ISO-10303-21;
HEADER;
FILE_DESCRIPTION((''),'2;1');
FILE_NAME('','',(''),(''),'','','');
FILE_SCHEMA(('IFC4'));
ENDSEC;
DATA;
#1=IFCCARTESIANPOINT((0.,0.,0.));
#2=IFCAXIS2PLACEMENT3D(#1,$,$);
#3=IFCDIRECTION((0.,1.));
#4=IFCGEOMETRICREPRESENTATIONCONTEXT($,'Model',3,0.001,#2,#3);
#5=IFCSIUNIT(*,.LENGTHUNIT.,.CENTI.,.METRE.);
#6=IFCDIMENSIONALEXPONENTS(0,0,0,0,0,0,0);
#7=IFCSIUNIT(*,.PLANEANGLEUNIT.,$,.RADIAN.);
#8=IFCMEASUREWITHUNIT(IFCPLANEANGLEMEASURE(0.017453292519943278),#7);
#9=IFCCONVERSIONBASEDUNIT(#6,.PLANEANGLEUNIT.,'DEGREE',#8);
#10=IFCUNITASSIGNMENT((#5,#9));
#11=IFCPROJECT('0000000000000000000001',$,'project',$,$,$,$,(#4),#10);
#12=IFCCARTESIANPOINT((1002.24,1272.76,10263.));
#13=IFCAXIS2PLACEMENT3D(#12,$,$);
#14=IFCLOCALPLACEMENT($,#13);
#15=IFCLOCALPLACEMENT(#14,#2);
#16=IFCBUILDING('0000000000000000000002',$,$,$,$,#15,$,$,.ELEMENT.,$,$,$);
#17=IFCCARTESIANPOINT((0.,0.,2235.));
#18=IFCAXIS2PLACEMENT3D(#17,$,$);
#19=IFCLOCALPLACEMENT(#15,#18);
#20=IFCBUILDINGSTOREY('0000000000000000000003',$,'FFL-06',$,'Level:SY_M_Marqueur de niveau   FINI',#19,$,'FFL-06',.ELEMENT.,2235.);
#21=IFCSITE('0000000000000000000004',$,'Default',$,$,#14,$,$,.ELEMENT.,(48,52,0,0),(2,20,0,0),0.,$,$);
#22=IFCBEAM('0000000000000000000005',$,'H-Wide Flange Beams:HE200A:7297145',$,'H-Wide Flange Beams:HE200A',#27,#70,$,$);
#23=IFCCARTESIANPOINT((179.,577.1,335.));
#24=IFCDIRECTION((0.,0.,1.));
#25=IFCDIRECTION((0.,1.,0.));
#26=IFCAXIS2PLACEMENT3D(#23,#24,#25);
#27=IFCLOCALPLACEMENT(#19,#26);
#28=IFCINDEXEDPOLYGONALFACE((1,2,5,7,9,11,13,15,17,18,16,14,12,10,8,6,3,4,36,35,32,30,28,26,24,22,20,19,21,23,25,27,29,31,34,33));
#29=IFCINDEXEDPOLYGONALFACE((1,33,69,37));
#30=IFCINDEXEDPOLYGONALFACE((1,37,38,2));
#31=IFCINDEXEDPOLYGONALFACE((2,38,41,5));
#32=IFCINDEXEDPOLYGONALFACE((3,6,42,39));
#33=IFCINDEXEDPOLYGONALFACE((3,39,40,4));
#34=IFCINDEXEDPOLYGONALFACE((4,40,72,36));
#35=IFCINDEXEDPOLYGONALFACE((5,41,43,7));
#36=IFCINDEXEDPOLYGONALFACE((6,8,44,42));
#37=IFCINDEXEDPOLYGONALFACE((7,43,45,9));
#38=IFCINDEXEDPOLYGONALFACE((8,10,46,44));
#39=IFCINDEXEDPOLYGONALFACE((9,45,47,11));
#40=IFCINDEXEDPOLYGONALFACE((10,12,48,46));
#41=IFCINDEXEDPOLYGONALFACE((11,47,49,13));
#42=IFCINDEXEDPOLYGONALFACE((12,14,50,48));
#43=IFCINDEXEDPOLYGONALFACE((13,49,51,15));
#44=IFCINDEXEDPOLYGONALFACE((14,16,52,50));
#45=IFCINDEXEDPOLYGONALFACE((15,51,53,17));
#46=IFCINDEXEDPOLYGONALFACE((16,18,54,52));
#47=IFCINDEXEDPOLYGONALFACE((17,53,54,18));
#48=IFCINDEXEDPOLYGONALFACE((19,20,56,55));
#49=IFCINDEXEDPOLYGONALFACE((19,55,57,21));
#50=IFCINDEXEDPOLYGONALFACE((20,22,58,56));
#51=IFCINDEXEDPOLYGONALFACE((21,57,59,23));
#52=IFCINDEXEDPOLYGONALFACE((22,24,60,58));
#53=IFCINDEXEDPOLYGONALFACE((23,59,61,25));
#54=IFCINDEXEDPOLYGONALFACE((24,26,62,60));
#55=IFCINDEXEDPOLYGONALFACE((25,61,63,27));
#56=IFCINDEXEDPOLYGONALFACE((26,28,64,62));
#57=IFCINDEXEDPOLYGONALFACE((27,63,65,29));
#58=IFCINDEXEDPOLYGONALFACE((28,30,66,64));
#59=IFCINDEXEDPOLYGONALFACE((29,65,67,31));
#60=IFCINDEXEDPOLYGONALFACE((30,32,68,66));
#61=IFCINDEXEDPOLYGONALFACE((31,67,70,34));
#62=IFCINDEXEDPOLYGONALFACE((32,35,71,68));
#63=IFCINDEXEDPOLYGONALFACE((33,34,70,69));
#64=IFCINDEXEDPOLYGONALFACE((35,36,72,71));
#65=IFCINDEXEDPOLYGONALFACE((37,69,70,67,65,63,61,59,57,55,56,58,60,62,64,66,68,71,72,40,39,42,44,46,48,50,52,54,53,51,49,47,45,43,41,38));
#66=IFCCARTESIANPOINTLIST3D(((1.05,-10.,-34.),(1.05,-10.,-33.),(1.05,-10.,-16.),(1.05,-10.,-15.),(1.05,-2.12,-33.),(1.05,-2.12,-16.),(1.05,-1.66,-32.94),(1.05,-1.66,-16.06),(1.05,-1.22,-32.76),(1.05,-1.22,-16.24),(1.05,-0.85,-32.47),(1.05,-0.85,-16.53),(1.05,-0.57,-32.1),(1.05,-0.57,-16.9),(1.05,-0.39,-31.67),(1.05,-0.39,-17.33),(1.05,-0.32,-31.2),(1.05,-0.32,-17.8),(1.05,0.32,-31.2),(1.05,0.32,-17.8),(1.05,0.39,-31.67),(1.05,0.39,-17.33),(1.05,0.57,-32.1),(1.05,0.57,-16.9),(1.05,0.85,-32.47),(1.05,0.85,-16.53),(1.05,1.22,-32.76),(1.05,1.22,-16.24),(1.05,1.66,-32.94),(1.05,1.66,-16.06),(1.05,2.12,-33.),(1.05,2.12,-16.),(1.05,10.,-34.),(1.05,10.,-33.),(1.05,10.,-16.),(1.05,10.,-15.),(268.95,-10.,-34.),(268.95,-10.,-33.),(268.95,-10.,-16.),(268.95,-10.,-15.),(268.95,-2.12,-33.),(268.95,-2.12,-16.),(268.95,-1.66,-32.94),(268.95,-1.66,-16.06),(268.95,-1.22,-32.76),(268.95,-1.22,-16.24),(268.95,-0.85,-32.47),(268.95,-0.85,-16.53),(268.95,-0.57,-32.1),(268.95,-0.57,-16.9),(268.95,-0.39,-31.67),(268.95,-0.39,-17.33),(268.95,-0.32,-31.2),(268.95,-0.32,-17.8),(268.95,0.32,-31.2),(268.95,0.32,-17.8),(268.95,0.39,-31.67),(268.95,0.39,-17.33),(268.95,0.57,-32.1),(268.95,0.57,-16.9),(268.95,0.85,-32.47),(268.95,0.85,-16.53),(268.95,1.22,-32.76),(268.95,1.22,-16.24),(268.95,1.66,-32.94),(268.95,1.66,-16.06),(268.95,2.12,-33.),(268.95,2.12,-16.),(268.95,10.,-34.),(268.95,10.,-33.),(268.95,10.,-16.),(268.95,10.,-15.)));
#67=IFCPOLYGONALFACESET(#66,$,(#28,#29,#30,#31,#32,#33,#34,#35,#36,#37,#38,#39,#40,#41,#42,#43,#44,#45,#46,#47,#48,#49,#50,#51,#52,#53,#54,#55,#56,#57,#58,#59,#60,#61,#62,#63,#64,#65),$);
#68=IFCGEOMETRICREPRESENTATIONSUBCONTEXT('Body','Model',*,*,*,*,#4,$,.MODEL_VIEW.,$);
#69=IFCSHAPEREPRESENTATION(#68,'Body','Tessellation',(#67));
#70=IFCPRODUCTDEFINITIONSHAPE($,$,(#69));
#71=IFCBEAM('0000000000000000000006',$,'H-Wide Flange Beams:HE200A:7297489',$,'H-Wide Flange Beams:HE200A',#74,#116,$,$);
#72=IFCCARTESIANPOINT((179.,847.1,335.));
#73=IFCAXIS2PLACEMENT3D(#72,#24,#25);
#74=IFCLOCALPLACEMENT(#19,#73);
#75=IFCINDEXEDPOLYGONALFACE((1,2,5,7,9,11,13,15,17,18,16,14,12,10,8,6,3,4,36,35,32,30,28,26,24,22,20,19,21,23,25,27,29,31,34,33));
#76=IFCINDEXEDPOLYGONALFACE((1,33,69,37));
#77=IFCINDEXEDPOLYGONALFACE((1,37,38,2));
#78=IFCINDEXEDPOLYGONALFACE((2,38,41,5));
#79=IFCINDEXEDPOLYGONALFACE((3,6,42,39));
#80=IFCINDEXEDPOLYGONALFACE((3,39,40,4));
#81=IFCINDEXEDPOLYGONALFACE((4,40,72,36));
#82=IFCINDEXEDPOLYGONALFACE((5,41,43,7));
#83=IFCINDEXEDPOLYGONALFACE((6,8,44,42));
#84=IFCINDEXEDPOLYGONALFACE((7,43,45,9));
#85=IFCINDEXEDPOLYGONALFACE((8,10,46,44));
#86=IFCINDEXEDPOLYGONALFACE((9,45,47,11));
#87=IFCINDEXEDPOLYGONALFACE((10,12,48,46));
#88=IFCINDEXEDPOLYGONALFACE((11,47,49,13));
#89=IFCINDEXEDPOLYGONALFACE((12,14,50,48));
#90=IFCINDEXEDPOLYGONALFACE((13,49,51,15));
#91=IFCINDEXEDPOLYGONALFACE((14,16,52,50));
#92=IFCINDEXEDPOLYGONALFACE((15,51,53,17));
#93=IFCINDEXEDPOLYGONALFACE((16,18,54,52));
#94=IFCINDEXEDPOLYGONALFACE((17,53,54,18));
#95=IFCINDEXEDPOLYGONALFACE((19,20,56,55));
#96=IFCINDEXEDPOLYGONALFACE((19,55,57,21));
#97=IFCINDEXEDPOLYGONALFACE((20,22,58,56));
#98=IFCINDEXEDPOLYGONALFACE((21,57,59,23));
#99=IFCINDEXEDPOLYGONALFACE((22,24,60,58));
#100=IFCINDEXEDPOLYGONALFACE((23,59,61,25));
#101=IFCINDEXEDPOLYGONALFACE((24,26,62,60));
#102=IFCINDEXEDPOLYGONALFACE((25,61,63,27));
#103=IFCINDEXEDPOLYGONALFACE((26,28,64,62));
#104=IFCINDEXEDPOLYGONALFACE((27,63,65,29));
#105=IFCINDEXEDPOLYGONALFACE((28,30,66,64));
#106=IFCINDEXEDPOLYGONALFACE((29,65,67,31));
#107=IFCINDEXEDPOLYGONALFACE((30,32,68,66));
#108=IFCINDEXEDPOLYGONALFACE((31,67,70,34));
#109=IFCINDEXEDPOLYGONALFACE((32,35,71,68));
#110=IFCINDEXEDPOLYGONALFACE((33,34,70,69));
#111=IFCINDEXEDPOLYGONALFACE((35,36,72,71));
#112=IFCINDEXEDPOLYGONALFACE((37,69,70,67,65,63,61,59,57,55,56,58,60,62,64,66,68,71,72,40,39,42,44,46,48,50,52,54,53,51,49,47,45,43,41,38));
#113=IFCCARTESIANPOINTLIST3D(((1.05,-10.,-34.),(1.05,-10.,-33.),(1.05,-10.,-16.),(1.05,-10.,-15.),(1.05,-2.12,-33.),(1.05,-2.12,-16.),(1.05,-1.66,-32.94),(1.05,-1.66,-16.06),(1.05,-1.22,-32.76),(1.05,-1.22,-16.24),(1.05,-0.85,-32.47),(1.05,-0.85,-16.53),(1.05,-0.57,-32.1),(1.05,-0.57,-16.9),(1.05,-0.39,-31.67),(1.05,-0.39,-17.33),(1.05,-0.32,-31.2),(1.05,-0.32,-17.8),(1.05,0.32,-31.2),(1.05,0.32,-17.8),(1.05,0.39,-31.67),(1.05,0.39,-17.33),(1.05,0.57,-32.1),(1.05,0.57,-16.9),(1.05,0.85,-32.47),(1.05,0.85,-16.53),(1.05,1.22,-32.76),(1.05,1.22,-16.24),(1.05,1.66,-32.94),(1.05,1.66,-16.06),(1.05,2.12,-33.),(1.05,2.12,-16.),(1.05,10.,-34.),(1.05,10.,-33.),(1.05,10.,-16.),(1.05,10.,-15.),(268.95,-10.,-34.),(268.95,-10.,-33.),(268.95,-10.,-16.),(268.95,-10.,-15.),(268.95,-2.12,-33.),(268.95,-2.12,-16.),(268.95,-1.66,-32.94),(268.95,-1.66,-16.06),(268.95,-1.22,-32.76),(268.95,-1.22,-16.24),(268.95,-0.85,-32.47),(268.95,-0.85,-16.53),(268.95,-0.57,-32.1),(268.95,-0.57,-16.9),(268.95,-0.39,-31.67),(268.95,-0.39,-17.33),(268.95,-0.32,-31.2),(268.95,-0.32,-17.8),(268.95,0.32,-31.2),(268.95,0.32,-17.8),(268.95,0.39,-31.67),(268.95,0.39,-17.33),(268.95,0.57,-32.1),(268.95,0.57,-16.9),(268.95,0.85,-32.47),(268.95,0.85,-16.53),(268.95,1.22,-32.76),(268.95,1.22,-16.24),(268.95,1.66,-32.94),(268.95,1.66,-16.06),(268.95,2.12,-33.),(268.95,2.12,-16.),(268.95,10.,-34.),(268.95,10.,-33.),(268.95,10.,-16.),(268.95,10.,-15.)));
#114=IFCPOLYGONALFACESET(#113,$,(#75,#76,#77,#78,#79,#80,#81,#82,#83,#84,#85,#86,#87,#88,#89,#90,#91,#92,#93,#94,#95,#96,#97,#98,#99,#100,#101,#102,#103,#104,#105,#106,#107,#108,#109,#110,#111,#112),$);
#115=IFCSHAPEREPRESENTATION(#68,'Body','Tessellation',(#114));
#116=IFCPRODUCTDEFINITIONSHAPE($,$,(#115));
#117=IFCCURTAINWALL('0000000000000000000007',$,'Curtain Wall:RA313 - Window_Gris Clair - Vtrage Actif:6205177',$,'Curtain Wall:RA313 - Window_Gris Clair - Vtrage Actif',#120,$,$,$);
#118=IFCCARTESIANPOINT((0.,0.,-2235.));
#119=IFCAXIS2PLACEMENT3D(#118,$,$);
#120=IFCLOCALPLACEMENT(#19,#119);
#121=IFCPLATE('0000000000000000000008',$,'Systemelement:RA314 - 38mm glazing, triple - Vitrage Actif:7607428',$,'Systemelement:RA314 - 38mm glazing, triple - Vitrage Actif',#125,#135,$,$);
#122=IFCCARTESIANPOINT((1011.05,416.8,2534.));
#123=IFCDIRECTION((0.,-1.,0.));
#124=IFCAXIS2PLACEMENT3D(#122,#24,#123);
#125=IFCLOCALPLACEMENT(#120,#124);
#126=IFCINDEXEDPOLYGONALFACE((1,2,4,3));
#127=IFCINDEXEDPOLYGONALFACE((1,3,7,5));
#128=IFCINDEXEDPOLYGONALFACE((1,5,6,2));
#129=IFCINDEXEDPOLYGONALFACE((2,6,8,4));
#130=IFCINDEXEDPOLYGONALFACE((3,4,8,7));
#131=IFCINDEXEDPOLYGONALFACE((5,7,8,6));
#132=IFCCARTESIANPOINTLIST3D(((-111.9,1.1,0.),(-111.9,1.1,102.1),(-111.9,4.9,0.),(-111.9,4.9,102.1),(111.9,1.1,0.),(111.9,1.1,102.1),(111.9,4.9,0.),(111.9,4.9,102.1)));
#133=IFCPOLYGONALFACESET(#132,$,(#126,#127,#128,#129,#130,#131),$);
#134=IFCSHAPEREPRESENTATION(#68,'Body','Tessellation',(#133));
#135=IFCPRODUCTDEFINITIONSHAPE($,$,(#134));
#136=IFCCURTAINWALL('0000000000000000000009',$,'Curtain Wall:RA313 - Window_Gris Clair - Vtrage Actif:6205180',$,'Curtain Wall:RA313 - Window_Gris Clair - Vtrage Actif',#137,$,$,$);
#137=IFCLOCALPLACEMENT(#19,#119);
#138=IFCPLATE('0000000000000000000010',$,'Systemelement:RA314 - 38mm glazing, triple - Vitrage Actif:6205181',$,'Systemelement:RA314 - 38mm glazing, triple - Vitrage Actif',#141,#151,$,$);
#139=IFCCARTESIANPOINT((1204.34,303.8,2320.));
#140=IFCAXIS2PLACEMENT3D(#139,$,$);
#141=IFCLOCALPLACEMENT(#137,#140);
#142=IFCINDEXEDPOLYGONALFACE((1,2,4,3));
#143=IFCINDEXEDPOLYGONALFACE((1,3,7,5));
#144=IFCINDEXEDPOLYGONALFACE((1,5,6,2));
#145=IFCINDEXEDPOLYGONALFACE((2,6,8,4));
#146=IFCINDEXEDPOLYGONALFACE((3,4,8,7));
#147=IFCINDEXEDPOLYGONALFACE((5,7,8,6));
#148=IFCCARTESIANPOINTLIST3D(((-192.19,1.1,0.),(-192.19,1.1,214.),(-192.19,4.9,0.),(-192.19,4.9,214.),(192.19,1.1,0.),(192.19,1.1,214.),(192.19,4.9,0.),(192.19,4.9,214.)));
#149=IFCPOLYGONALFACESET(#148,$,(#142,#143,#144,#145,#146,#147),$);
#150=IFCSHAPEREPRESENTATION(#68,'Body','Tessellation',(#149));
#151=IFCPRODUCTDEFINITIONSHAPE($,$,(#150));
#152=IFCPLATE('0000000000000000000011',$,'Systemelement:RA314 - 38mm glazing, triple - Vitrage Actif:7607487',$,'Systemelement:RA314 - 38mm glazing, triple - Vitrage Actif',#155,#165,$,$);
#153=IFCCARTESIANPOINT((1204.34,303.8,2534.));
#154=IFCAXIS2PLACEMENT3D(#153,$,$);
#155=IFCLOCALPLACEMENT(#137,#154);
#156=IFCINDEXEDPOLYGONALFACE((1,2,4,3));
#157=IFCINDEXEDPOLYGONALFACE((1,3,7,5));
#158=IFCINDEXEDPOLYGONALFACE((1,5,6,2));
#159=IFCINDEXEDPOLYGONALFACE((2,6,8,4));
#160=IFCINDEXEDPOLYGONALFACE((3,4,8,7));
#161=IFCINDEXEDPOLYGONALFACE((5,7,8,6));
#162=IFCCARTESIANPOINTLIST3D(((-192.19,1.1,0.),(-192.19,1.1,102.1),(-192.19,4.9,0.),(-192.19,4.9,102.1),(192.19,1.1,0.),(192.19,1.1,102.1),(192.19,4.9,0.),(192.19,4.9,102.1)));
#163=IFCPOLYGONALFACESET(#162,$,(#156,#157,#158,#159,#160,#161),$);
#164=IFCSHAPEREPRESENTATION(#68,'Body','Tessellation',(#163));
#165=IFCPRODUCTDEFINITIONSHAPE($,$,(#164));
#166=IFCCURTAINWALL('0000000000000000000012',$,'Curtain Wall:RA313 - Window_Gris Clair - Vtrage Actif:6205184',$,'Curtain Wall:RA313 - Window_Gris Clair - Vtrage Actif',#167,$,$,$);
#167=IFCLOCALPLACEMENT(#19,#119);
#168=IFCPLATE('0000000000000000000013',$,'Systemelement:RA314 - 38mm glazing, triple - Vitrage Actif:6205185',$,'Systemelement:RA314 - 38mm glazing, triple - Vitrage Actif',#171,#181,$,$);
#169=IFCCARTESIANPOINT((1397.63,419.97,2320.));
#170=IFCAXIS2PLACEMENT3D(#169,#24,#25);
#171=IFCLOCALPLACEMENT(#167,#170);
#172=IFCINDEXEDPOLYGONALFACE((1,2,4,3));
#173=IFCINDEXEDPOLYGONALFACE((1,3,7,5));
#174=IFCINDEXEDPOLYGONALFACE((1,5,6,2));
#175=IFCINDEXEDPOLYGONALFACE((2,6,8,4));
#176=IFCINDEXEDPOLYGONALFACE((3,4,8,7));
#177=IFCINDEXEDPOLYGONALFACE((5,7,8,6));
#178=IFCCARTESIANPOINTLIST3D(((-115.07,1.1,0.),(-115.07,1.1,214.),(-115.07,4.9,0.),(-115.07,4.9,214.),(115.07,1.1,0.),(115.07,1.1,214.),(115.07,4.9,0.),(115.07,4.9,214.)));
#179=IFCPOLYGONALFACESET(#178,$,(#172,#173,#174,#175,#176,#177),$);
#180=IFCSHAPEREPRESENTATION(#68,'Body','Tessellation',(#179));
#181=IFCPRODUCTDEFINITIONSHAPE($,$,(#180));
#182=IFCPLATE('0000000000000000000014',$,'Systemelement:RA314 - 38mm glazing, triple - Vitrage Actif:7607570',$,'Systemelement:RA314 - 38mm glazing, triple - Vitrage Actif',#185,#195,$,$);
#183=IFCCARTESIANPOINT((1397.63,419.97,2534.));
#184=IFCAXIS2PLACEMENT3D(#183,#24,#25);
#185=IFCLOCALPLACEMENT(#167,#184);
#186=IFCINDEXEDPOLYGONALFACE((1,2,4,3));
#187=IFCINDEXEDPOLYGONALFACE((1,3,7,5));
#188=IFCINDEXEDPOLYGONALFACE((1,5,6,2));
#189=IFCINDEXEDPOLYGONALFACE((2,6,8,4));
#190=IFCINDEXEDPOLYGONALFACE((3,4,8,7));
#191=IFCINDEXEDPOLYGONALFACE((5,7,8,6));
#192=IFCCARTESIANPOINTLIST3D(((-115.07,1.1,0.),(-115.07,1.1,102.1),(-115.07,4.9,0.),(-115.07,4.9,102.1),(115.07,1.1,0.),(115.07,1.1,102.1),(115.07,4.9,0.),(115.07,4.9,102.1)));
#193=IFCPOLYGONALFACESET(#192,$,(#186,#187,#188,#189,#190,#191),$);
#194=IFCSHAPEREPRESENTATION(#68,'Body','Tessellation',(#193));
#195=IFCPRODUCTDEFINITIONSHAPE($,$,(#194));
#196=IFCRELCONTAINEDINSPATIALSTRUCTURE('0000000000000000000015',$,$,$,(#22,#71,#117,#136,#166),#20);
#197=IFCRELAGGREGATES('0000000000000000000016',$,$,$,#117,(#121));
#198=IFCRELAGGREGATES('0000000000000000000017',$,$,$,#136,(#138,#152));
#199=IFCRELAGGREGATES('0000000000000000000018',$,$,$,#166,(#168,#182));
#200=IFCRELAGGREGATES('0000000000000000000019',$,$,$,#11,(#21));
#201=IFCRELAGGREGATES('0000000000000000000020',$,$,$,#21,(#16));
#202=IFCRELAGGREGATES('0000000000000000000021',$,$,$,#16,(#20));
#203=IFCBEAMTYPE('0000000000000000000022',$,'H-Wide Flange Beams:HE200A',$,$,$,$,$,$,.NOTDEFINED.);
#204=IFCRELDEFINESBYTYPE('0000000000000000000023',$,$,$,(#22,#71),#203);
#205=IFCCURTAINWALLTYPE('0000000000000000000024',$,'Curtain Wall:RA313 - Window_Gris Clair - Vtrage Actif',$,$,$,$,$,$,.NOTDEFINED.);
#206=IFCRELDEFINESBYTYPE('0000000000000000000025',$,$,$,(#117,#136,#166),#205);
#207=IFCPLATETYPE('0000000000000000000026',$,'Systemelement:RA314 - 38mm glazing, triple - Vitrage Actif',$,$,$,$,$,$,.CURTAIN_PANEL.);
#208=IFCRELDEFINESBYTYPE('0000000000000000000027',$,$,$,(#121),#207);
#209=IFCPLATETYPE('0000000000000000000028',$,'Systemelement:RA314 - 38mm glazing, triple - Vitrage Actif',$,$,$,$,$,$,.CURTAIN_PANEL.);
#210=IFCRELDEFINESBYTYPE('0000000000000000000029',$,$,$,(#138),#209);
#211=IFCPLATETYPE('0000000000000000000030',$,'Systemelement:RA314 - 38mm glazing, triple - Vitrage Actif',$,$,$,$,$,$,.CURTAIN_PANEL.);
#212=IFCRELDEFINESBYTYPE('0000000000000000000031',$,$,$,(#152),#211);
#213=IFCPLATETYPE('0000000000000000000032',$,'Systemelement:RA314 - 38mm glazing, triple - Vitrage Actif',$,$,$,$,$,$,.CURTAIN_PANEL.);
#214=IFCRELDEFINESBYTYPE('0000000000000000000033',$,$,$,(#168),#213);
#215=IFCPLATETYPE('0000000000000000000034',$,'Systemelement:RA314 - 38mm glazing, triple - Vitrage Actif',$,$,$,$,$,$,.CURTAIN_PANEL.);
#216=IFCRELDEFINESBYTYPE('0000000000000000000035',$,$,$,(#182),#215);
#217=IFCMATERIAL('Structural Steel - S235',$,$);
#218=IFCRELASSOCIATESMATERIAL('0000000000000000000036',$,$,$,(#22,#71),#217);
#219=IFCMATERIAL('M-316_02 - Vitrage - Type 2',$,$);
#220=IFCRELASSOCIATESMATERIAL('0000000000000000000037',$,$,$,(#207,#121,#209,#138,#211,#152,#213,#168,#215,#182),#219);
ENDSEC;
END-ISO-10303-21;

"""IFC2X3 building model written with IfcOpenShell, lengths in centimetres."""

from ifc_helpers import new_model, entity, si_unit, converted_unit, direction, frame, frame_2d, origin, origin_2d_with_axis, place, context, subcontext, project, spatial, rectangle, i_section, extrude, source, transform, mapped, material, type_object, type_shapes, element, aggregate, save


model = new_model("IFC2X3")

# Units and contexts
model_context = context("Model", 3, precision=0.001, world=origin(), true_north=direction((0.0, 1.0)))
body_context = subcontext(model_context, "Body", "Model", "MODEL_VIEW")
ifc_project = project(units=[si_unit("LENGTHUNIT", "METRE", prefix="CENTI"), converted_unit("PLANEANGLEUNIT", "DEGREE", entity("IfcPlaneAngleMeasure", 0.017453292519943278), si_unit("PLANEANGLEUNIT", "RADIAN"), dimensions=[0, 0, 0, 0, 0, 0, 0])], contexts=[model_context])

# Site, building, storey
site_placement = place(None, frame((1002.24, 1272.76, 10263.0)))
site = spatial("IfcSite", under=ifc_project, at=site_placement, Name="Default", CompositionType="ELEMENT", RefLatitude=(48, 52, 0, 0), RefLongitude=(2, 20, 0, 0), RefElevation=0.0)
building_placement = place(site_placement, origin())
building = spatial("IfcBuilding", under=site, at=building_placement, CompositionType="ELEMENT")
storey_placement = place(building_placement, frame((0.0, 0.0, 2235.0)))
storey = spatial("IfcBuildingStorey", under=building, at=storey_placement, Name="FFL-06", ObjectType="Level:SY_M_Marqueur de niveau   FINI", LongName="FFL-06", CompositionType="ELEMENT", Elevation=2235.0)

# Shared definitions
ifc_material_1 = material(Name="Structural Steel - S235")

# Beams
beam_type_1 = type_object("IfcBeamType", Name="H-Wide Flange Beams:HE200A", PredefinedType="NOTDEFINED")
beam_1_placement = place(storey_placement, frame((179.0, 577.1, 335.0), z_axis=(0.0, 0.0, 1.0), x_axis=(0.0, 1.0, 0.0)))
element("IfcBeam", 1, at=beam_1_placement, inside=storey, type_object=beam_type_1, material=ifc_material_1, Name="H-Wide Flange Beams:HE200A:7297145", ObjectType="H-Wide Flange Beams:HE200A", context=body_context, shape_type="SweptSolid", body=[
    extrude(i_section(OverallWidth=20.0, OverallDepth=19.0, WebThickness=0.65, FlangeThickness=1.0, FilletRadius=1.8, at=frame_2d((0.0, 0.0), x_axis=(0.0, 1.0))), frame((1.05, 0.0, -24.5), z_axis=(1.0, 0.0, 0.0), x_axis=(0.0, 0.0, -1.0)), (0.0, 0.0, 1.0), 267.9),
])
beam_2_placement = place(storey_placement, frame((179.0, 847.1, 335.0), z_axis=(0.0, 0.0, 1.0), x_axis=(0.0, 1.0, 0.0)))
element("IfcBeam", 2, at=beam_2_placement, inside=storey, type_object=beam_type_1, material=ifc_material_1, Name="H-Wide Flange Beams:HE200A:7297489", ObjectType="H-Wide Flange Beams:HE200A", context=body_context, shape_type="SweptSolid", body=[
    extrude(i_section(OverallWidth=20.0, OverallDepth=19.0, WebThickness=0.65, FlangeThickness=1.0, FilletRadius=1.8, at=frame_2d((0.0, 0.0), x_axis=(0.0, 1.0))), frame((1.05, 0.0, -24.5), z_axis=(1.0, 0.0, 0.0), x_axis=(0.0, 0.0, -1.0)), (0.0, 0.0, 1.0), 267.9),
])

# Curtain wall, plate
curtain_wall_type_1 = type_object("IfcCurtainWallType", Name="Curtain Wall:RA313 - Window_Gris Clair - Vtrage Actif", PredefinedType="NOTDEFINED")
curtain_wall_1_placement = place(storey_placement, frame((0.0, 0.0, -2235.0)))
curtain_wall_1 = element("IfcCurtainWall", 3, at=curtain_wall_1_placement, inside=storey, type_object=curtain_wall_type_1, Name="Curtain Wall:RA313 - Window_Gris Clair - Vtrage Actif:6205177", ObjectType="Curtain Wall:RA313 - Window_Gris Clair - Vtrage Actif")
ifc_material_2 = material(Name="M-316_02 - Vitrage - Type 2")
plate_type_1 = type_object("IfcPlateType", Name="Systemelement:RA314 - 38mm glazing, triple - Vitrage Actif", PredefinedType="CURTAIN_PANEL", material=ifc_material_2)
shared_shape_1 = source(origin(), body_context, "Body", "SweptSolid", [
    extrude(rectangle(XDim=3.8, YDim=223.8, at=origin_2d_with_axis()), frame((0.0, 3.0, 0.0), z_axis=(0.0, 0.0, 1.0), x_axis=(0.0, 1.0, 0.0)), (0.0, 0.0, 1.0), 102.1),
])
type_shapes(plate_type_1, [shared_shape_1])
plate_1_placement = place(curtain_wall_1_placement, frame((1011.05, 416.8, 2534.0), z_axis=(0.0, 0.0, 1.0), x_axis=(0.0, -1.0, 0.0)))
plate_1 = element("IfcPlate", 4, at=plate_1_placement, type_object=plate_type_1, material=ifc_material_2, Name="Systemelement:RA314 - 38mm glazing, triple - Vitrage Actif:7607428", ObjectType="Systemelement:RA314 - 38mm glazing, triple - Vitrage Actif", context=body_context, shape_type="MappedRepresentation", body=[
    mapped(shared_shape_1, transform((0.0, 0.0, 0.0), scale=1.0)),
])
aggregate(curtain_wall_1, [plate_1])

# Curtain walls, plates
curtain_wall_2_placement = place(storey_placement, frame((0.0, 0.0, -2235.0)))
curtain_wall_2 = element("IfcCurtainWall", 5, at=curtain_wall_2_placement, inside=storey, type_object=curtain_wall_type_1, Name="Curtain Wall:RA313 - Window_Gris Clair - Vtrage Actif:6205180", ObjectType="Curtain Wall:RA313 - Window_Gris Clair - Vtrage Actif")
plate_type_2 = type_object("IfcPlateType", Name="Systemelement:RA314 - 38mm glazing, triple - Vitrage Actif", PredefinedType="CURTAIN_PANEL", material=ifc_material_2)
shared_shape_2 = source(origin(), body_context, "Body", "SweptSolid", [
    extrude(rectangle(XDim=3.8, YDim=384.38, at=frame_2d((0.0, 0.0), x_axis=(1.0, 0.0))), frame((0.0, 3.0, 0.0), z_axis=(0.0, 0.0, 1.0), x_axis=(0.0, 1.0, 0.0)), (0.0, 0.0, 1.0), 214.0),
])
type_shapes(plate_type_2, [shared_shape_2])
plate_2_placement = place(curtain_wall_2_placement, frame((1204.34, 303.8, 2320.0)))
plate_2 = element("IfcPlate", 6, at=plate_2_placement, type_object=plate_type_2, material=ifc_material_2, Name="Systemelement:RA314 - 38mm glazing, triple - Vitrage Actif:6205181", ObjectType="Systemelement:RA314 - 38mm glazing, triple - Vitrage Actif", context=body_context, shape_type="MappedRepresentation", body=[
    mapped(shared_shape_2, transform((0.0, 0.0, 0.0), scale=1.0)),
])
plate_type_3 = type_object("IfcPlateType", Name="Systemelement:RA314 - 38mm glazing, triple - Vitrage Actif", PredefinedType="CURTAIN_PANEL", material=ifc_material_2)
shared_shape_3 = source(origin(), body_context, "Body", "SweptSolid", [
    extrude(rectangle(XDim=3.8, YDim=384.38, at=frame_2d((0.0, 0.0), x_axis=(1.0, 0.0))), frame((0.0, 3.0, 0.0), z_axis=(0.0, 0.0, 1.0), x_axis=(0.0, 1.0, 0.0)), (0.0, 0.0, 1.0), 102.1),
])
type_shapes(plate_type_3, [shared_shape_3])
plate_3_placement = place(curtain_wall_2_placement, frame((1204.34, 303.8, 2534.0)))
plate_3 = element("IfcPlate", 7, at=plate_3_placement, type_object=plate_type_3, material=ifc_material_2, Name="Systemelement:RA314 - 38mm glazing, triple - Vitrage Actif:7607487", ObjectType="Systemelement:RA314 - 38mm glazing, triple - Vitrage Actif", context=body_context, shape_type="MappedRepresentation", body=[
    mapped(shared_shape_3, transform((0.0, 0.0, 0.0), scale=1.0)),
])
aggregate(curtain_wall_2, [plate_2, plate_3])
curtain_wall_3_placement = place(storey_placement, frame((0.0, 0.0, -2235.0)))
curtain_wall_3 = element("IfcCurtainWall", 8, at=curtain_wall_3_placement, inside=storey, type_object=curtain_wall_type_1, Name="Curtain Wall:RA313 - Window_Gris Clair - Vtrage Actif:6205184", ObjectType="Curtain Wall:RA313 - Window_Gris Clair - Vtrage Actif")
plate_type_4 = type_object("IfcPlateType", Name="Systemelement:RA314 - 38mm glazing, triple - Vitrage Actif", PredefinedType="CURTAIN_PANEL", material=ifc_material_2)
shared_shape_4 = source(origin(), body_context, "Body", "SweptSolid", [
    extrude(rectangle(XDim=3.8, YDim=230.14, at=frame_2d((0.0, 0.0), x_axis=(1.0, 0.0))), frame((0.0, 3.0, 0.0), z_axis=(0.0, 0.0, 1.0), x_axis=(0.0, 1.0, 0.0)), (0.0, 0.0, 1.0), 214.0),
])
type_shapes(plate_type_4, [shared_shape_4])
plate_4_placement = place(curtain_wall_3_placement, frame((1397.63, 419.97, 2320.0), z_axis=(0.0, 0.0, 1.0), x_axis=(0.0, 1.0, 0.0)))
plate_4 = element("IfcPlate", 9, at=plate_4_placement, type_object=plate_type_4, material=ifc_material_2, Name="Systemelement:RA314 - 38mm glazing, triple - Vitrage Actif:6205185", ObjectType="Systemelement:RA314 - 38mm glazing, triple - Vitrage Actif", context=body_context, shape_type="MappedRepresentation", body=[
    mapped(shared_shape_4, transform((0.0, 0.0, 0.0), scale=1.0)),
])
plate_type_5 = type_object("IfcPlateType", Name="Systemelement:RA314 - 38mm glazing, triple - Vitrage Actif", PredefinedType="CURTAIN_PANEL", material=ifc_material_2)
shared_shape_5 = source(origin(), body_context, "Body", "SweptSolid", [
    extrude(rectangle(XDim=3.8, YDim=230.14, at=frame_2d((0.0, 0.0), x_axis=(1.0, 0.0))), frame((0.0, 3.0, 0.0), z_axis=(0.0, 0.0, 1.0), x_axis=(0.0, 1.0, 0.0)), (0.0, 0.0, 1.0), 102.1),
])
type_shapes(plate_type_5, [shared_shape_5])
plate_5_placement = place(curtain_wall_3_placement, frame((1397.63, 419.97, 2534.0), z_axis=(0.0, 0.0, 1.0), x_axis=(0.0, 1.0, 0.0)))
plate_5 = element("IfcPlate", 10, at=plate_5_placement, type_object=plate_type_5, material=ifc_material_2, Name="Systemelement:RA314 - 38mm glazing, triple - Vitrage Actif:7607570", ObjectType="Systemelement:RA314 - 38mm glazing, triple - Vitrage Actif", context=body_context, shape_type="MappedRepresentation", body=[
    mapped(shared_shape_5, transform((0.0, 0.0, 0.0), scale=1.0)),
])
aggregate(curtain_wall_3, [plate_4, plate_5])

save(model, "model.ifc")
